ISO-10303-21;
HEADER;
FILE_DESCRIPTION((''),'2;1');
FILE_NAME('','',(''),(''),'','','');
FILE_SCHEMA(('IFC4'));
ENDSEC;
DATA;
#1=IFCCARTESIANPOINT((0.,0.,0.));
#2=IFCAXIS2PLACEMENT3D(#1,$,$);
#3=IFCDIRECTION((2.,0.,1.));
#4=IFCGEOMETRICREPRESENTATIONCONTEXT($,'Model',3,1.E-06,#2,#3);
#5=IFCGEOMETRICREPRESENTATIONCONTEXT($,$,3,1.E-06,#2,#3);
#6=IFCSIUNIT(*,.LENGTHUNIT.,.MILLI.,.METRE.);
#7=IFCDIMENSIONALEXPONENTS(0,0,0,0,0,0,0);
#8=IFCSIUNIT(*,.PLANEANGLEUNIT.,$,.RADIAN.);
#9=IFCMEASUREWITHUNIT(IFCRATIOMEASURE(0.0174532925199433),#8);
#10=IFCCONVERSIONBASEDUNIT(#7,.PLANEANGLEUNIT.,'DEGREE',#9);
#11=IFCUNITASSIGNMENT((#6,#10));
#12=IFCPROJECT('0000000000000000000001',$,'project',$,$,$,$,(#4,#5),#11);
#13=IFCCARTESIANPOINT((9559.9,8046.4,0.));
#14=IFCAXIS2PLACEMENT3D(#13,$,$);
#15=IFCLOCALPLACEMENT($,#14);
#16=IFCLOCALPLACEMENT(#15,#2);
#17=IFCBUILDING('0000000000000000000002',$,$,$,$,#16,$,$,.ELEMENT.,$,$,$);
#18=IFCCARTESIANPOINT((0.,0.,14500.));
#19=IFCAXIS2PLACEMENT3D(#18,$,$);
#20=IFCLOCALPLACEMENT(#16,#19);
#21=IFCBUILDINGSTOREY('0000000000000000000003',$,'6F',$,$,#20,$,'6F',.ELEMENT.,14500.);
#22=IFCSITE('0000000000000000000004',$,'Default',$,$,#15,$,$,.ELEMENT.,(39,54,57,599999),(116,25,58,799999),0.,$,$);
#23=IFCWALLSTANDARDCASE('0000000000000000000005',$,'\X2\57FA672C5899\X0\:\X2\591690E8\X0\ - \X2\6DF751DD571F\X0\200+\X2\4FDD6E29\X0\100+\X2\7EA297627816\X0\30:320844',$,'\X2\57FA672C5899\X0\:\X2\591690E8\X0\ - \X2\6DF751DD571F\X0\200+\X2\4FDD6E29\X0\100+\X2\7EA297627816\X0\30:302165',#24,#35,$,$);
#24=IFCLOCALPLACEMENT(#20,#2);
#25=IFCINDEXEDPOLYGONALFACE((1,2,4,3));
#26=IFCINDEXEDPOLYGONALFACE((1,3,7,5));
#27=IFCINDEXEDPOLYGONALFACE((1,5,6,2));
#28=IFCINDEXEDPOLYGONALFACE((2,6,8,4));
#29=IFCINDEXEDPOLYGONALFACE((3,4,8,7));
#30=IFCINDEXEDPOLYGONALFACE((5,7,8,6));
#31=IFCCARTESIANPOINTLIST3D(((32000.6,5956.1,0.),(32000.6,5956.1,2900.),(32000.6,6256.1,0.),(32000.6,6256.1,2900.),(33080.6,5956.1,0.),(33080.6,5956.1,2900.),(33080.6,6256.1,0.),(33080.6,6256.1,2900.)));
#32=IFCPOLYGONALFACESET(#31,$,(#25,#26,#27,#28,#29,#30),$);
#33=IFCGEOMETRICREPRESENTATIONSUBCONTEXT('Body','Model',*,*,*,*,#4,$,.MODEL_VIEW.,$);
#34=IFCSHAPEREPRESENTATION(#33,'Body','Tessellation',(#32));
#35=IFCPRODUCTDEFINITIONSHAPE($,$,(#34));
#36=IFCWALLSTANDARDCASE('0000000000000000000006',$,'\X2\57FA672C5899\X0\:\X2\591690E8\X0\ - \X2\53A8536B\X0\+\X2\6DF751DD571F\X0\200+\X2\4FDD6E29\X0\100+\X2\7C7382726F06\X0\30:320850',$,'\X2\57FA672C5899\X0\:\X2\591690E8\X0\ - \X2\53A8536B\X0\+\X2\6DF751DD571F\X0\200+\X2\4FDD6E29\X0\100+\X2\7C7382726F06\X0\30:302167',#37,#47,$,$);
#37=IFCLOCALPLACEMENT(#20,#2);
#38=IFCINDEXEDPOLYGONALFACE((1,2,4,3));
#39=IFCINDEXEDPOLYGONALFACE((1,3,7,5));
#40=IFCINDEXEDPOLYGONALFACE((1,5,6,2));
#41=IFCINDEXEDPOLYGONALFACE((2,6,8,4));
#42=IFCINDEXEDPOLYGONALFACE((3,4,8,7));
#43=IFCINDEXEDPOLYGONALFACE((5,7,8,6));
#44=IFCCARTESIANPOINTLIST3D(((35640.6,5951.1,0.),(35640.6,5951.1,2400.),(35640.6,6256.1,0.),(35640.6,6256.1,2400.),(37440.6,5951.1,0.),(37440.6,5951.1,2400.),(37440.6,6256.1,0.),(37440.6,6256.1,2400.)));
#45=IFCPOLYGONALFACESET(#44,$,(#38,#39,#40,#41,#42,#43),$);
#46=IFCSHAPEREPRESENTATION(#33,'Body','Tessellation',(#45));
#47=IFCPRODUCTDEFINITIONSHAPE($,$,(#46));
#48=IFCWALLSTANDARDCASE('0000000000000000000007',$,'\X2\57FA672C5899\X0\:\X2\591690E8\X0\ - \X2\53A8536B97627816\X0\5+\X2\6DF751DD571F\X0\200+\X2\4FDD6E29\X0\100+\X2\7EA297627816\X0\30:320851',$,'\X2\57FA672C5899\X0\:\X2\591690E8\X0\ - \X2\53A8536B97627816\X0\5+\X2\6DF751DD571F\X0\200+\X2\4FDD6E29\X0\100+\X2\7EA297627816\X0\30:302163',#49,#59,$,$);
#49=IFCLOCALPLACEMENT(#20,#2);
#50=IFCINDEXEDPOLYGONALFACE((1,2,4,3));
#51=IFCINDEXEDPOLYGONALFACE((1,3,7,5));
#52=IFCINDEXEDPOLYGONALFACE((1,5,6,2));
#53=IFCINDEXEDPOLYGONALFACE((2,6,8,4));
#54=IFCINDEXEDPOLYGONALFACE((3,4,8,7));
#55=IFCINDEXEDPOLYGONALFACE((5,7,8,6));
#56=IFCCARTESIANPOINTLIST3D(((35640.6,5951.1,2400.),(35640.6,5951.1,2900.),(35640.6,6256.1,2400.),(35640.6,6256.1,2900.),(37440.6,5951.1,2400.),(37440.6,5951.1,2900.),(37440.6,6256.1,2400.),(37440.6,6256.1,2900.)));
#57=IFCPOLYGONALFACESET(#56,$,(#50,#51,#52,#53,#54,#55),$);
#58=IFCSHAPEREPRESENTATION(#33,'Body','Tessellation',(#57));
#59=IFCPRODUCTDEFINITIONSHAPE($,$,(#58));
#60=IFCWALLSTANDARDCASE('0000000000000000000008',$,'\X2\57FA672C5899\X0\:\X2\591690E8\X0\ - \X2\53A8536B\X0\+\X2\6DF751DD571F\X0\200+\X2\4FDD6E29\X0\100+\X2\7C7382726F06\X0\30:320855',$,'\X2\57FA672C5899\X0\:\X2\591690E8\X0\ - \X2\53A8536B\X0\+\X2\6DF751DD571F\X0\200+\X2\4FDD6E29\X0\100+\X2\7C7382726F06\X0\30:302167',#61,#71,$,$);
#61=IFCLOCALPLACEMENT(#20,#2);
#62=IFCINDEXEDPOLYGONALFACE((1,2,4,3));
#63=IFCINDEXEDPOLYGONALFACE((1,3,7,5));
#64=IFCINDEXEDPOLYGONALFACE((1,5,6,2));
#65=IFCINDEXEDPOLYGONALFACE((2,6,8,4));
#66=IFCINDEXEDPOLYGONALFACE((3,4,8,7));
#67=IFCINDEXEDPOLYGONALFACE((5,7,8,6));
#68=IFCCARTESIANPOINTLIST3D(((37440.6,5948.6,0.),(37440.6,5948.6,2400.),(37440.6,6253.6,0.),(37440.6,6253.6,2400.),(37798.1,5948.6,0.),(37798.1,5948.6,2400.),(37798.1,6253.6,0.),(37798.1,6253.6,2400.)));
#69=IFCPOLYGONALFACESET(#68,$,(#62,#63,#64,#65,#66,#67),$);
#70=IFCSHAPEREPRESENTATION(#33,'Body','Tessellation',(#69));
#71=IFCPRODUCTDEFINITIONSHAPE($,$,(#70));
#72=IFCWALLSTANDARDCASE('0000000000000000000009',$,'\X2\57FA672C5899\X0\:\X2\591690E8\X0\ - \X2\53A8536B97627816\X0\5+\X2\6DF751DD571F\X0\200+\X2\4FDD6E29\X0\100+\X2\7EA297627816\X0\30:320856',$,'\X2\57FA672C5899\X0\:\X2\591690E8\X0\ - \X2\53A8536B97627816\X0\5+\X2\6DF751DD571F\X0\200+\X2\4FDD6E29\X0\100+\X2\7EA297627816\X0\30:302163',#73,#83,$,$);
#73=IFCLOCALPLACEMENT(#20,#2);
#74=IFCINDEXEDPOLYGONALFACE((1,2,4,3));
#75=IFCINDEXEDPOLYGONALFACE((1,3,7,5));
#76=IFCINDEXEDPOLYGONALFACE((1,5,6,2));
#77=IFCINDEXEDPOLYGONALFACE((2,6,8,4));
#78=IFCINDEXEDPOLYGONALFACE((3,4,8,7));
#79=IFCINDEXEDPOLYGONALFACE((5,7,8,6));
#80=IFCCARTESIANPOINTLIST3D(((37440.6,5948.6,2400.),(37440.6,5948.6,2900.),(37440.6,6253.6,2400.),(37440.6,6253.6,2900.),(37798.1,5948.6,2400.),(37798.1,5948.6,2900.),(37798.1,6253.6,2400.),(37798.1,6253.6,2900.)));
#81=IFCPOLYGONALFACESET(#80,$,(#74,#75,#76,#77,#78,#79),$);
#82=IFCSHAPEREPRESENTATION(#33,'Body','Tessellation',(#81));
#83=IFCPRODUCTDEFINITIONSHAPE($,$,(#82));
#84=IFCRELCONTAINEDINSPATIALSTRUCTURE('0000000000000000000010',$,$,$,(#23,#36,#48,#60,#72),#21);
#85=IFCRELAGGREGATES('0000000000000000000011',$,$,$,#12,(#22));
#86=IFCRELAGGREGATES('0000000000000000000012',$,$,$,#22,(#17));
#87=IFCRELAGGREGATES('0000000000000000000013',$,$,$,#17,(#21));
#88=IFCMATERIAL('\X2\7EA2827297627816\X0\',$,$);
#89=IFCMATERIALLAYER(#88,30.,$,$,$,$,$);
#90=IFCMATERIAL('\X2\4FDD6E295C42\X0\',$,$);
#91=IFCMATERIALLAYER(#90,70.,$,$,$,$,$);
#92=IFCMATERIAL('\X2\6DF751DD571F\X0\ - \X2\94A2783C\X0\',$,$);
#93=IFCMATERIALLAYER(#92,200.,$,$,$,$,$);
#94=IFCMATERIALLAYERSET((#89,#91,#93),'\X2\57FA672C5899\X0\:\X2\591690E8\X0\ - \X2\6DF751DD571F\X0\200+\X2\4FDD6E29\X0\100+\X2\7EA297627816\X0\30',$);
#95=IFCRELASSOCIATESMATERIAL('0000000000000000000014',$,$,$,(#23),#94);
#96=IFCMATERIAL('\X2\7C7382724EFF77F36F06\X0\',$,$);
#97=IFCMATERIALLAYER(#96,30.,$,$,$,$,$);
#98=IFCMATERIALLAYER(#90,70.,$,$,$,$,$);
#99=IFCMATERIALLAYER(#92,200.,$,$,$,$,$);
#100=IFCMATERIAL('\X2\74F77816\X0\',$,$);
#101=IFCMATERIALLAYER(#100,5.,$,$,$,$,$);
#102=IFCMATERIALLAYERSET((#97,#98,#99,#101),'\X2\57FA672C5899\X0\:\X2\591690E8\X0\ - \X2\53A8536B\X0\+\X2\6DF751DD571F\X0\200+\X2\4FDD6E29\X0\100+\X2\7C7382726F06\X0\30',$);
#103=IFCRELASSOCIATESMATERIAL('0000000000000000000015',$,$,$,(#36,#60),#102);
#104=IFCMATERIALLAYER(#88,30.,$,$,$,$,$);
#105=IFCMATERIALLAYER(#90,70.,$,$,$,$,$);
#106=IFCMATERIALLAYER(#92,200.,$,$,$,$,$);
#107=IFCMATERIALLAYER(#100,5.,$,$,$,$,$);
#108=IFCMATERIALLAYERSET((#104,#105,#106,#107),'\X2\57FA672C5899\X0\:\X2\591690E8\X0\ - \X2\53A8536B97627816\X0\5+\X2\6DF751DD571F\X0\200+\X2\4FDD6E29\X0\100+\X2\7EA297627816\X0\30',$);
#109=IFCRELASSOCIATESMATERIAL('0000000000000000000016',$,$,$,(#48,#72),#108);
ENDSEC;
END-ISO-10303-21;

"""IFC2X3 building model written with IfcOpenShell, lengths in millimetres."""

from ifc_helpers import new_model, entity, si_unit, converted_unit, direction, frame, frame_2d, origin, place, context, subcontext, project, spatial, rectangle, extrude, material, layer, layer_set, layer_usage, element, save


model = new_model("IFC2X3")

# Units and contexts
model_context = context("Model", 3, precision=1e-06, world=origin(), true_north=direction((2.0, 0.0, 1.0)))
context_of_model = context(None, 3, precision=1e-06, world=origin(), true_north=direction((2.0, 0.0, 1.0)))
body_context = subcontext(model_context, "Body", "Model", "MODEL_VIEW")
ifc_project = project(units=[si_unit("LENGTHUNIT", "METRE", prefix="MILLI"), converted_unit("PLANEANGLEUNIT", "DEGREE", entity("IfcRatioMeasure", 0.0174532925199433), si_unit("PLANEANGLEUNIT", "RADIAN"), dimensions=[0, 0, 0, 0, 0, 0, 0])], contexts=[model_context, context_of_model])

# Site, building, storey
site_placement = place(None, frame((9559.9, 8046.4, 0.0)))
site = spatial("IfcSite", under=ifc_project, at=site_placement, Name="Default", CompositionType="ELEMENT", RefLatitude=(39, 54, 57, 599999), RefLongitude=(116, 25, 58, 799999), RefElevation=0.0)
building_placement = place(site_placement, origin())
building = spatial("IfcBuilding", under=site, at=building_placement, CompositionType="ELEMENT")
storey_placement = place(building_placement, frame((0.0, 0.0, 14500.0)))
storey = spatial("IfcBuildingStorey", under=building, at=storey_placement, Name="6F", LongName="6F", CompositionType="ELEMENT", Elevation=14500.0)

# Shared definitions
ifc_material_1 = material(Name="混凝土 - 钢砼")
ifc_material_2 = material(Name="瓷砖")

# Shared definitions
ifc_material_3 = material(Name="红色面砖")
ifc_layer_1 = layer(ifc_material_3, 30.0)
ifc_material_4 = material(Name="保温层")
ifc_layer_2 = layer(ifc_material_4, 70.0)
ifc_layer_3 = layer(ifc_material_1, 200.0)
ifc_layer_set_1 = layer_set([ifc_layer_1, ifc_layer_2, ifc_layer_3], Name="基本墙:外部 - 混凝土200+保温100+红面砖30")

# Shared definitions
ifc_layer_4 = layer(ifc_material_3, 30.0)
ifc_layer_5 = layer(ifc_material_4, 70.0)
ifc_layer_6 = layer(ifc_material_1, 200.0)
ifc_layer_7 = layer(ifc_material_2, 5.0)
ifc_layer_set_2 = layer_set([ifc_layer_4, ifc_layer_5, ifc_layer_6, ifc_layer_7], Name="基本墙:外部 - 厨卫面砖5+混凝土200+保温100+红面砖30")

# Walls
ifc_layer_usage_1 = layer_usage(ifc_layer_set_1, "AXIS2", "POSITIVE", -150.0)
wall_1_placement = place(storey_placement, frame((33080.6, 6106.1, 0.0), z_axis=(0.0, 0.0, 1.0), x_axis=(-1.0, 0.0, 0.0)))
element("IfcWallStandardCase", 1, at=wall_1_placement, inside=storey, material=ifc_layer_usage_1, Name="基本墙:外部 - 混凝土200+保温100+红面砖30:320844", ObjectType="基本墙:外部 - 混凝土200+保温100+红面砖30:302165", context=body_context, shape_type="SweptSolid", body=[
    extrude(rectangle(XDim=1080.0, YDim=300.0, at=frame_2d((540.0, 0.0), x_axis=(-1.0, 0.0))), origin(), (0.0, 0.0, 1.0), 2900.0),
])
ifc_material_5 = material(Name="米色仿石漆")
ifc_layer_8 = layer(ifc_material_5, 30.0)
ifc_layer_9 = layer(ifc_material_4, 70.0)
ifc_layer_10 = layer(ifc_material_1, 200.0)
ifc_layer_11 = layer(ifc_material_2, 5.0)
ifc_layer_set_3 = layer_set([ifc_layer_8, ifc_layer_9, ifc_layer_10, ifc_layer_11], Name="基本墙:外部 - 厨卫+混凝土200+保温100+米色漆30")
ifc_layer_usage_2 = layer_usage(ifc_layer_set_3, "AXIS2", "POSITIVE", -152.5)
wall_2_placement = place(storey_placement, frame((37440.6, 6103.6, 0.0), z_axis=(0.0, 0.0, 1.0), x_axis=(-1.0, 0.0, 0.0)))
element("IfcWallStandardCase", 2, at=wall_2_placement, inside=storey, material=ifc_layer_usage_2, Name="基本墙:外部 - 厨卫+混凝土200+保温100+米色漆30:320850", ObjectType="基本墙:外部 - 厨卫+混凝土200+保温100+米色漆30:302167", context=body_context, shape_type="SweptSolid", body=[
    extrude(rectangle(XDim=1800.0, YDim=305.0, at=frame_2d((900.0, 0.0), x_axis=(-1.0, 0.0))), origin(), (0.0, 0.0, 1.0), 2400.0),
])
ifc_layer_usage_3 = layer_usage(ifc_layer_set_2, "AXIS2", "POSITIVE", -152.5)
wall_3_placement = place(storey_placement, frame((37440.6, 6103.6, 2400.0), z_axis=(0.0, 0.0, 1.0), x_axis=(-1.0, 0.0, 0.0)))
element("IfcWallStandardCase", 3, at=wall_3_placement, inside=storey, material=ifc_layer_usage_3, Name="基本墙:外部 - 厨卫面砖5+混凝土200+保温100+红面砖30:320851", ObjectType="基本墙:外部 - 厨卫面砖5+混凝土200+保温100+红面砖30:302163", context=body_context, shape_type="SweptSolid", body=[
    extrude(rectangle(XDim=1800.0, YDim=305.0, at=frame_2d((900.0, 0.0), x_axis=(-1.0, 0.0))), origin(), (0.0, 0.0, 1.0), 500.0),
])
ifc_layer_usage_4 = layer_usage(ifc_layer_set_3, "AXIS2", "POSITIVE", -152.5)
wall_4_placement = place(storey_placement, frame((37798.1, 6101.1, 0.0), z_axis=(0.0, 0.0, 1.0), x_axis=(-1.0, 0.0, 0.0)))
element("IfcWallStandardCase", 4, at=wall_4_placement, inside=storey, material=ifc_layer_usage_4, Name="基本墙:外部 - 厨卫+混凝土200+保温100+米色漆30:320855", ObjectType="基本墙:外部 - 厨卫+混凝土200+保温100+米色漆30:302167", context=body_context, shape_type="SweptSolid", body=[
    extrude(rectangle(XDim=357.5, YDim=305.0, at=frame_2d((178.7, 0.0), x_axis=(-1.0, 0.0))), origin(), (0.0, 0.0, 1.0), 2400.0),
])
ifc_layer_usage_5 = layer_usage(ifc_layer_set_2, "AXIS2", "POSITIVE", -152.5)
wall_5_placement = place(storey_placement, frame((37798.1, 6101.1, 2400.0), z_axis=(0.0, 0.0, 1.0), x_axis=(-1.0, 0.0, 0.0)))
element("IfcWallStandardCase", 5, at=wall_5_placement, inside=storey, material=ifc_layer_usage_5, Name="基本墙:外部 - 厨卫面砖5+混凝土200+保温100+红面砖30:320856", ObjectType="基本墙:外部 - 厨卫面砖5+混凝土200+保温100+红面砖30:302163", context=body_context, shape_type="SweptSolid", body=[
    extrude(rectangle(XDim=357.5, YDim=305.0, at=frame_2d((178.7, 0.0), x_axis=(-1.0, 0.0))), origin(), (0.0, 0.0, 1.0), 500.0),
])

save(model, "model.ifc")
